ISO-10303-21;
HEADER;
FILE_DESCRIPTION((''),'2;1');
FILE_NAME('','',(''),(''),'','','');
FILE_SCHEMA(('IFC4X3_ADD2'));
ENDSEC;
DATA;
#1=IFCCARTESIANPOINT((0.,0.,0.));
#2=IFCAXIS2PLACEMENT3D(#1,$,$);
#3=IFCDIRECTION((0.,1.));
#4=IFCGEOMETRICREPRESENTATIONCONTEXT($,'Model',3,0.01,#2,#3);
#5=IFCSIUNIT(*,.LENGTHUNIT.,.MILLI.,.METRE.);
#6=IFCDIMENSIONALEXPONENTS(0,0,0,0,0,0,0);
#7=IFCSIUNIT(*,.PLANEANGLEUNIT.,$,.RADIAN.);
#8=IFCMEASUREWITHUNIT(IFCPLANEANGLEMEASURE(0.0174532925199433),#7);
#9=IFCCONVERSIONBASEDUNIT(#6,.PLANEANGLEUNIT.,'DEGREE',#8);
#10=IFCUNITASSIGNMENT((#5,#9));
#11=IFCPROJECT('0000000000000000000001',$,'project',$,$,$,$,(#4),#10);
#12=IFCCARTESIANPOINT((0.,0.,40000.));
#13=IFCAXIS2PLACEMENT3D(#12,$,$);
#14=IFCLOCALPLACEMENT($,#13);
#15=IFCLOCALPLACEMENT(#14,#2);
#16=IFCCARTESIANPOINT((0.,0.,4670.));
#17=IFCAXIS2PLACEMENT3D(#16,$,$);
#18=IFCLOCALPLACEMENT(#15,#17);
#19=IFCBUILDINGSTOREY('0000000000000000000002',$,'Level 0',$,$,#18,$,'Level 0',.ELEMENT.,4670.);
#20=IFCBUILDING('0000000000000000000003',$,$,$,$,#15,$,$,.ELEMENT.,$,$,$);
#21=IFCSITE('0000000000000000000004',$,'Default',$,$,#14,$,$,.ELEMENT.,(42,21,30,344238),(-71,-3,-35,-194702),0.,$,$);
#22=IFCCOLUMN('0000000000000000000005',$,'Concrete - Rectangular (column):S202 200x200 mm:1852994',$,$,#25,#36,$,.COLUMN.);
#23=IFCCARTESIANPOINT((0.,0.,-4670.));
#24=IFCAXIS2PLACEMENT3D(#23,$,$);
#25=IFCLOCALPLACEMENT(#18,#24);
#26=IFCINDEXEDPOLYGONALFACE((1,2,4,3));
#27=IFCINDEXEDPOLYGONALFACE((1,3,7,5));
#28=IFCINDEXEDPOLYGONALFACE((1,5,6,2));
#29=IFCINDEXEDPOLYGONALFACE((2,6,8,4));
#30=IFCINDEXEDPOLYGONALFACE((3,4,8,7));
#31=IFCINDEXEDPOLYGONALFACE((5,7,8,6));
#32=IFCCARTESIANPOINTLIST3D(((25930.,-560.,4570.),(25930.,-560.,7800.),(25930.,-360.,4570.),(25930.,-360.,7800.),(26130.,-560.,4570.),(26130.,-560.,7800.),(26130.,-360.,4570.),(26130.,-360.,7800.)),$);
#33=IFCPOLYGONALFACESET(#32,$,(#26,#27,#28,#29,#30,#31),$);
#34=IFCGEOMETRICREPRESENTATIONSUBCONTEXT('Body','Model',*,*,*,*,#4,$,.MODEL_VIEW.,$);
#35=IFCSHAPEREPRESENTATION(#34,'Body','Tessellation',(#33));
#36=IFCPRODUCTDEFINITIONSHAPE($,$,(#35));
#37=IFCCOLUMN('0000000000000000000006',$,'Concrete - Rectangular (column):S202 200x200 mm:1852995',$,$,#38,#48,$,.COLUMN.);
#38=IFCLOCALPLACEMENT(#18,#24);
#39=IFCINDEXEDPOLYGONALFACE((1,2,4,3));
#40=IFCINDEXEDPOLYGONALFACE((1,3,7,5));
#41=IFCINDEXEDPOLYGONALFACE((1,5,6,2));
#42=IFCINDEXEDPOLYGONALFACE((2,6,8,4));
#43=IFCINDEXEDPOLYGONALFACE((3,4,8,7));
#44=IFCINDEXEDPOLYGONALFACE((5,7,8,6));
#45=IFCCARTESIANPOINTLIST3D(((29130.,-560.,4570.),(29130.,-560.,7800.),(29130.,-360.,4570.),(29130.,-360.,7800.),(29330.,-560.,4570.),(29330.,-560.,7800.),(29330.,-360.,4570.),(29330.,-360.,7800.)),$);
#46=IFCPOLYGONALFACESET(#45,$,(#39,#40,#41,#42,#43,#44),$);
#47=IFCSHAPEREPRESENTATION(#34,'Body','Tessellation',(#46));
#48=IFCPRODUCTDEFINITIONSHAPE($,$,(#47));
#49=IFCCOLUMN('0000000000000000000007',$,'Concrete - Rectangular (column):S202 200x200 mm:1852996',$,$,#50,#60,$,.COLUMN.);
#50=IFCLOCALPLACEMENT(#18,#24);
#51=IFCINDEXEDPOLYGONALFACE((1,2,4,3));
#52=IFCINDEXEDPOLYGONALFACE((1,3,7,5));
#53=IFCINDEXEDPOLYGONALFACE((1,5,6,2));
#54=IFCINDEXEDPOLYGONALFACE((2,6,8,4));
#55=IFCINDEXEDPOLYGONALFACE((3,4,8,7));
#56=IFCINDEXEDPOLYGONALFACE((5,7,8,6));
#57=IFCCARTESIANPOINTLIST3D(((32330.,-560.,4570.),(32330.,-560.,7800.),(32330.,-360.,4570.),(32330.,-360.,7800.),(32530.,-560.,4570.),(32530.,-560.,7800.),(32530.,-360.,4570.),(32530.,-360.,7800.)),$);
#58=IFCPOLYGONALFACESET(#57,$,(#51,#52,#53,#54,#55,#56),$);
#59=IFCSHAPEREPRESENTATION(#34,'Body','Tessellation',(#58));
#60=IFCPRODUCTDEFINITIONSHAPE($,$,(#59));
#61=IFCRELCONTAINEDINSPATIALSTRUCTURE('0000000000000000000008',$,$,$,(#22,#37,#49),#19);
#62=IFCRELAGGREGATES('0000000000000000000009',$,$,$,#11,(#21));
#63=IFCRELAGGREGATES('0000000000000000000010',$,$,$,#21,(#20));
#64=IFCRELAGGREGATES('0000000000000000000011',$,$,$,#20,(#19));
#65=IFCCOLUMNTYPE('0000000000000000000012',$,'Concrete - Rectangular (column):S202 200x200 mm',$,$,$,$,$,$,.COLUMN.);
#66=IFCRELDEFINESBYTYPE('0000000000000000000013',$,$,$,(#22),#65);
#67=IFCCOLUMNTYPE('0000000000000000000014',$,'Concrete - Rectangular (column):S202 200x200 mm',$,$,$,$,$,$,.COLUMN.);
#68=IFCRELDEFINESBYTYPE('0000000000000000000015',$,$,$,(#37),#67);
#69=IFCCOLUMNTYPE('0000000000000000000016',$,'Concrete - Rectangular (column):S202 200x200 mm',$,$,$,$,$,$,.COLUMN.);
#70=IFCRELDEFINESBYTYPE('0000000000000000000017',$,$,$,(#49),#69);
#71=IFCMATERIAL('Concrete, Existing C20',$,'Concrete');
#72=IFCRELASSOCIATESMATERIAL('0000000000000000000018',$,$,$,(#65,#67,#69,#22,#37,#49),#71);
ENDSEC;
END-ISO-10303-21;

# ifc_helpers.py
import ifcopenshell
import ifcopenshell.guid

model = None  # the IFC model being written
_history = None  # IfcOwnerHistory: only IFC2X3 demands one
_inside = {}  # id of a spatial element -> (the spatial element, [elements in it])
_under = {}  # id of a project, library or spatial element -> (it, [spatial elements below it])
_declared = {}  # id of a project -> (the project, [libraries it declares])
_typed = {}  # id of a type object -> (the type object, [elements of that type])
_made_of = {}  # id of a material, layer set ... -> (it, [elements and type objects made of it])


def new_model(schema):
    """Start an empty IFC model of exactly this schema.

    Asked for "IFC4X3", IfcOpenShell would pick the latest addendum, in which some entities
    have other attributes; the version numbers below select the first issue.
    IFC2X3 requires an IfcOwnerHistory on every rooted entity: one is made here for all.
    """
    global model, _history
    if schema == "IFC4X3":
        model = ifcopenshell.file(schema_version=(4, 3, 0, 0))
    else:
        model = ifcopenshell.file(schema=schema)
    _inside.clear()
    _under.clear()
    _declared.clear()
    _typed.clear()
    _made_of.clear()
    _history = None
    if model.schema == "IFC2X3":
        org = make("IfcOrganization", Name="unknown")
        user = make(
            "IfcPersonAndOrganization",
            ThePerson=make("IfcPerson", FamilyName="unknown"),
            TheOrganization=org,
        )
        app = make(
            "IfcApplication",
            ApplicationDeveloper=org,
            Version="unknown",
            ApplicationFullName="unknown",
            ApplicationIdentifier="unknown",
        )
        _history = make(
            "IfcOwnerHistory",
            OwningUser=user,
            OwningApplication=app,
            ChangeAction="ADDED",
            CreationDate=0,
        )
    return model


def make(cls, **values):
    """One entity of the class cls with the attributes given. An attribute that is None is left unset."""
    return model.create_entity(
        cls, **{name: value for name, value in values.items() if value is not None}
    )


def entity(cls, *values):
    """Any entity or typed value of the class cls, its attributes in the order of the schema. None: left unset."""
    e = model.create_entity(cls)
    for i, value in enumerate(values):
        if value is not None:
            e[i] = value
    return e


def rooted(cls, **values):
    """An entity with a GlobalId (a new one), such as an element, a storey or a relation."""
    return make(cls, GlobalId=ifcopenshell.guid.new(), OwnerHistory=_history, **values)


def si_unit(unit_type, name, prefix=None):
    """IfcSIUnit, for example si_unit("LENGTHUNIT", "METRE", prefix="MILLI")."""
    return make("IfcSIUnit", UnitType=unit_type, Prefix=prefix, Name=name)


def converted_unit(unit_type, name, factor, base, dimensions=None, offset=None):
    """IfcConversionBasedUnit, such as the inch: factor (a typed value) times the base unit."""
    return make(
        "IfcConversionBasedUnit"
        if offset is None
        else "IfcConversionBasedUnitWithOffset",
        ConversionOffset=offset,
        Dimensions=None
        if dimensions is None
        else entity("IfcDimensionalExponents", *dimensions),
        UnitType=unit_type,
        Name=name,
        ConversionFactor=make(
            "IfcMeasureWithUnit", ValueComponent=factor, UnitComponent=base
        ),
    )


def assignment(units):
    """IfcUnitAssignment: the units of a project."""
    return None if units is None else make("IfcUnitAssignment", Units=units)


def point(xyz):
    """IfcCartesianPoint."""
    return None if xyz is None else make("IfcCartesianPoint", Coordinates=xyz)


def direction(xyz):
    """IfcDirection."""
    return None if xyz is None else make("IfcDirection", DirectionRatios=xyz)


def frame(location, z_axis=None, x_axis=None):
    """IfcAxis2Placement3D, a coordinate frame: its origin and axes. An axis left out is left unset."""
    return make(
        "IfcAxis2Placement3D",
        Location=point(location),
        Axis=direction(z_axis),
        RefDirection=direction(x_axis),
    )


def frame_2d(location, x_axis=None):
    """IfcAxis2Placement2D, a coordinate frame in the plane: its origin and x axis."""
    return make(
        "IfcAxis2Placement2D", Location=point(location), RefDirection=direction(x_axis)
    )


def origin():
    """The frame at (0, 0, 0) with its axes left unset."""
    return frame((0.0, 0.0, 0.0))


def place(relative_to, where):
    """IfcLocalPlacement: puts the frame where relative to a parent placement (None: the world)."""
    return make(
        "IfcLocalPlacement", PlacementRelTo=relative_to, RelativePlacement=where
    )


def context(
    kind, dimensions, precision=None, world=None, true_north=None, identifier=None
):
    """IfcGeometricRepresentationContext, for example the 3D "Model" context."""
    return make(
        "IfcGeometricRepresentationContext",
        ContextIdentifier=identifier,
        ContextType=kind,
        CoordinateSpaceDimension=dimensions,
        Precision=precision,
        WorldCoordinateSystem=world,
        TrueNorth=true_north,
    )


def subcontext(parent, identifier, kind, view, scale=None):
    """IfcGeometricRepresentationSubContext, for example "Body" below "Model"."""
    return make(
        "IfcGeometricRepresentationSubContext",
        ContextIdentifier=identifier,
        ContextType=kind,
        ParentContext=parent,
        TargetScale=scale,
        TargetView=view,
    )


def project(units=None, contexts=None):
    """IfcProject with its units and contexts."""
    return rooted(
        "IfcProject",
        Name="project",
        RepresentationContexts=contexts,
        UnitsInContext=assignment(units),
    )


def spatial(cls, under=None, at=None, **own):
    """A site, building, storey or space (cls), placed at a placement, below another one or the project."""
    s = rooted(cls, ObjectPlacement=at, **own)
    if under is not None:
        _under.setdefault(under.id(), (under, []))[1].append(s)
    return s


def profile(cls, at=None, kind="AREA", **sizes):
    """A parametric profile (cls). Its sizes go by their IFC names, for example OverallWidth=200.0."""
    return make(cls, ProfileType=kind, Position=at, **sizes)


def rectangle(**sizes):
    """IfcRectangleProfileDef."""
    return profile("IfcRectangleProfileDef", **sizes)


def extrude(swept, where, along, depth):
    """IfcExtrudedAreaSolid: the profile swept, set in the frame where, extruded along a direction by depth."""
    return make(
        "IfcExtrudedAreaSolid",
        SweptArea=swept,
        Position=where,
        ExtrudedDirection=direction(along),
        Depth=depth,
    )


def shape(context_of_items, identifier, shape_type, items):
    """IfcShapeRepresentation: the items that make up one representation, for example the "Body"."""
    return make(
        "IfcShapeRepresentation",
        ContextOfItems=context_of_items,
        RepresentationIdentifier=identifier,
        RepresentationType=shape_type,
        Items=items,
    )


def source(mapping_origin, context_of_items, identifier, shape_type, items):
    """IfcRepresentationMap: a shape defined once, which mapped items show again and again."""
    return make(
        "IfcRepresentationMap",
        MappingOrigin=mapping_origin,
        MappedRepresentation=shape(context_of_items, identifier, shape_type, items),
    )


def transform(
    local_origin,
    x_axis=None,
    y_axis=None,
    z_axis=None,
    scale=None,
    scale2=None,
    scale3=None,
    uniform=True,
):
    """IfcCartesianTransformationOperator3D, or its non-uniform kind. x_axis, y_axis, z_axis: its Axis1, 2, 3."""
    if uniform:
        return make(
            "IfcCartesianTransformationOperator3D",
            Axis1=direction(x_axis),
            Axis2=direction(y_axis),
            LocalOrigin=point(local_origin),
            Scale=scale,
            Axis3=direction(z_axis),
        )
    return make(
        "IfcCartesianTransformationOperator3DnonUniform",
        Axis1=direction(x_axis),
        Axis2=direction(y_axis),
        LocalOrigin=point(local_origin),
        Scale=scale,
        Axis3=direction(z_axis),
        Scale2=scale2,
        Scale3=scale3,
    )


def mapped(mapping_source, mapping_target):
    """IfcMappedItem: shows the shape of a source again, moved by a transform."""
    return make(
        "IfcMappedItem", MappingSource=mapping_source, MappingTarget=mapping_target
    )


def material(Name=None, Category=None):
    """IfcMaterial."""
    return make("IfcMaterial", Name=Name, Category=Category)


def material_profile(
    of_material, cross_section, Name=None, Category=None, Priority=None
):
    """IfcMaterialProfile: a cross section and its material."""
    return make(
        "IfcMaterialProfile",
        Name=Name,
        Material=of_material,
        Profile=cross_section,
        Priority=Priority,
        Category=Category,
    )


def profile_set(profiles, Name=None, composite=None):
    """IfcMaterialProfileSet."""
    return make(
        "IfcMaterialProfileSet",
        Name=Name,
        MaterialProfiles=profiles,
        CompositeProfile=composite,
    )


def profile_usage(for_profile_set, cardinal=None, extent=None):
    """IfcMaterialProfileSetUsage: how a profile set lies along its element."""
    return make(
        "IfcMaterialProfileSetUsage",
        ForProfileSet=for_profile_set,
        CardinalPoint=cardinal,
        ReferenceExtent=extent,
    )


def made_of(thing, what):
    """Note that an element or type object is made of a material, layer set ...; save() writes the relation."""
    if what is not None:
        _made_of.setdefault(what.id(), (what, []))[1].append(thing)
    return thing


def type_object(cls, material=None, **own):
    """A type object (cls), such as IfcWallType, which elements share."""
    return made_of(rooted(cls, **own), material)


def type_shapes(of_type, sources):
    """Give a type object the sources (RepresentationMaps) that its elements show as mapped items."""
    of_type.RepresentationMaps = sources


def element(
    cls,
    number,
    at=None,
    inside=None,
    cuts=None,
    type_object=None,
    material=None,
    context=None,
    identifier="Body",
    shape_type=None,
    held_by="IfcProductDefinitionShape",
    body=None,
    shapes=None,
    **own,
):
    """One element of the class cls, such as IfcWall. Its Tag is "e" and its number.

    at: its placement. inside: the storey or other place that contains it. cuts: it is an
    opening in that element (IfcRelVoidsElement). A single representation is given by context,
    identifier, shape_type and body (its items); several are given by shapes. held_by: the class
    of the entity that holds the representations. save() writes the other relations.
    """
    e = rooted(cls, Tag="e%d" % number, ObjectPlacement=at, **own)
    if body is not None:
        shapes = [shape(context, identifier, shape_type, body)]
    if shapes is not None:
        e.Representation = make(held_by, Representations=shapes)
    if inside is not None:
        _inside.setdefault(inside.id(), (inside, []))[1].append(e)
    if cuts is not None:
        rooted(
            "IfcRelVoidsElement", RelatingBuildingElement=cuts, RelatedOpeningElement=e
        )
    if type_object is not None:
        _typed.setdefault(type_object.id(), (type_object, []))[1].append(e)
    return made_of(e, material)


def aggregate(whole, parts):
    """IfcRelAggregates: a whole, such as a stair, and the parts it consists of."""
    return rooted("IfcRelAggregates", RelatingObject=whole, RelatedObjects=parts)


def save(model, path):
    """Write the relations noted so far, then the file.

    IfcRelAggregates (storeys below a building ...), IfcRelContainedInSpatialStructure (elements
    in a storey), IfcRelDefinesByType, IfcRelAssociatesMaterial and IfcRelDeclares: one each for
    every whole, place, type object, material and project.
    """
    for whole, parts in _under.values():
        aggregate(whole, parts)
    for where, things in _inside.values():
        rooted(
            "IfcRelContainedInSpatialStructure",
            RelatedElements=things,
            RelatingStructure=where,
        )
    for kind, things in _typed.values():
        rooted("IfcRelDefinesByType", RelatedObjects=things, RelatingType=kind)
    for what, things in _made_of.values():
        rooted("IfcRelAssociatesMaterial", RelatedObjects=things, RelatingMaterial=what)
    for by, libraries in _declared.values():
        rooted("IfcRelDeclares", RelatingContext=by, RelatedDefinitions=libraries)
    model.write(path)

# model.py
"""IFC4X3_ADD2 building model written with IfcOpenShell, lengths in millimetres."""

from ifc_helpers import new_model, entity, si_unit, converted_unit, direction, frame, frame_2d, origin, place, context, subcontext, project, spatial, rectangle, extrude, source, transform, mapped, material, material_profile, profile_set, profile_usage, type_object, type_shapes, element, save


model = new_model("IFC4X3_ADD2")

# Units and contexts
model_context = context("Model", 3, precision=0.01, world=origin(), true_north=direction((0.0, 1.0)))
body_context = subcontext(model_context, "Body", "Model", "MODEL_VIEW")
ifc_project = project(units=[si_unit("LENGTHUNIT", "METRE", prefix="MILLI"), converted_unit("PLANEANGLEUNIT", "DEGREE", entity("IfcPlaneAngleMeasure", 0.0174532925199433), si_unit("PLANEANGLEUNIT", "RADIAN"), dimensions=[0, 0, 0, 0, 0, 0, 0])], contexts=[model_context])

# Site, building, storey
site_placement = place(None, frame((0.0, 0.0, 40000.0)))
site = spatial("IfcSite", under=ifc_project, at=site_placement, Name="Default", CompositionType="ELEMENT", RefLatitude=(42, 21, 30, 344238), RefLongitude=(-71, -3, -35, -194702), RefElevation=0.0)
building_placement = place(site_placement, origin())
building = spatial("IfcBuilding", under=site, at=building_placement, CompositionType="ELEMENT")
storey_placement = place(building_placement, frame((0.0, 0.0, 4670.0)))
storey = spatial("IfcBuildingStorey", under=building, at=storey_placement, Name="Level 0", LongName="Level 0", CompositionType="ELEMENT", Elevation=4670.0)

# Columns
ifc_material = material(Name="Concrete, Existing C20", Category="Concrete")
ifc_material_profile_1 = material_profile(ifc_material, rectangle(XDim=200.0, YDim=200.0, at=frame_2d((0.0, 0.0), x_axis=(1.0, 0.0))), Name="S202 200x200 mm")
ifc_profile_set_1 = profile_set([ifc_material_profile_1], Name="S202 200x200 mm")
ifc_profile_usage_1 = profile_usage(ifc_profile_set_1)
column_type_1 = type_object("IfcColumnType", Name="Concrete - Rectangular (column):S202 200x200 mm", PredefinedType="COLUMN", material=ifc_profile_set_1)
shared_shape_1 = source(origin(), body_context, "Body", "SweptSolid", [
    extrude(rectangle(XDim=200.0, YDim=200.0, at=frame_2d((-20.0, 0.0), x_axis=(1.0, 0.0))), frame((26030.0, -440.0, 4570.0), z_axis=(0.0, 0.0, 1.0), x_axis=(0.0, 1.0, 0.0)), (0.0, 0.0, 1.0), 3230.0),
])
type_shapes(column_type_1, [shared_shape_1])
column_1_placement = place(storey_placement, frame((0.0, 0.0, -4670.0)))
element("IfcColumn", 1, at=column_1_placement, inside=storey, type_object=column_type_1, material=ifc_profile_usage_1, Name="Concrete - Rectangular (column):S202 200x200 mm:1852994", PredefinedType="COLUMN", context=body_context, shape_type="MappedRepresentation", body=[
    mapped(shared_shape_1, transform((0.0, 0.0, 0.0), scale=1.0)),
])
column_type_2 = type_object("IfcColumnType", Name="Concrete - Rectangular (column):S202 200x200 mm", PredefinedType="COLUMN", material=ifc_profile_set_1)
shared_shape_2 = source(origin(), body_context, "Body", "SweptSolid", [
    extrude(rectangle(XDim=200.0, YDim=200.0, at=frame_2d((-20.0, 0.0), x_axis=(1.0, 0.0))), frame((29230.0, -440.0, 4570.0), z_axis=(0.0, 0.0, 1.0), x_axis=(0.0, 1.0, 0.0)), (0.0, 0.0, 1.0), 3230.0),
])
type_shapes(column_type_2, [shared_shape_2])
column_2_placement = place(storey_placement, frame((0.0, 0.0, -4670.0)))
element("IfcColumn", 2, at=column_2_placement, inside=storey, type_object=column_type_2, material=ifc_profile_usage_1, Name="Concrete - Rectangular (column):S202 200x200 mm:1852995", PredefinedType="COLUMN", context=body_context, shape_type="MappedRepresentation", body=[
    mapped(shared_shape_2, transform((0.0, 0.0, 0.0), scale=1.0)),
])
column_type_3 = type_object("IfcColumnType", Name="Concrete - Rectangular (column):S202 200x200 mm", PredefinedType="COLUMN", material=ifc_profile_set_1)
shared_shape_3 = source(origin(), body_context, "Body", "SweptSolid", [
    extrude(rectangle(XDim=200.0, YDim=200.0, at=frame_2d((-20.0, 0.0), x_axis=(1.0, 0.0))), frame((32430.0, -440.0, 4570.0), z_axis=(0.0, 0.0, 1.0), x_axis=(0.0, 1.0, 0.0)), (0.0, 0.0, 1.0), 3230.0),
])
type_shapes(column_type_3, [shared_shape_3])
column_3_placement = place(storey_placement, frame((0.0, 0.0, -4670.0)))
element("IfcColumn", 3, at=column_3_placement, inside=storey, type_object=column_type_3, material=ifc_profile_usage_1, Name="Concrete - Rectangular (column):S202 200x200 mm:1852996", PredefinedType="COLUMN", context=body_context, shape_type="MappedRepresentation", body=[
    mapped(shared_shape_3, transform((0.0, 0.0, 0.0), scale=1.0)),
])

save(model, "model.ifc")
